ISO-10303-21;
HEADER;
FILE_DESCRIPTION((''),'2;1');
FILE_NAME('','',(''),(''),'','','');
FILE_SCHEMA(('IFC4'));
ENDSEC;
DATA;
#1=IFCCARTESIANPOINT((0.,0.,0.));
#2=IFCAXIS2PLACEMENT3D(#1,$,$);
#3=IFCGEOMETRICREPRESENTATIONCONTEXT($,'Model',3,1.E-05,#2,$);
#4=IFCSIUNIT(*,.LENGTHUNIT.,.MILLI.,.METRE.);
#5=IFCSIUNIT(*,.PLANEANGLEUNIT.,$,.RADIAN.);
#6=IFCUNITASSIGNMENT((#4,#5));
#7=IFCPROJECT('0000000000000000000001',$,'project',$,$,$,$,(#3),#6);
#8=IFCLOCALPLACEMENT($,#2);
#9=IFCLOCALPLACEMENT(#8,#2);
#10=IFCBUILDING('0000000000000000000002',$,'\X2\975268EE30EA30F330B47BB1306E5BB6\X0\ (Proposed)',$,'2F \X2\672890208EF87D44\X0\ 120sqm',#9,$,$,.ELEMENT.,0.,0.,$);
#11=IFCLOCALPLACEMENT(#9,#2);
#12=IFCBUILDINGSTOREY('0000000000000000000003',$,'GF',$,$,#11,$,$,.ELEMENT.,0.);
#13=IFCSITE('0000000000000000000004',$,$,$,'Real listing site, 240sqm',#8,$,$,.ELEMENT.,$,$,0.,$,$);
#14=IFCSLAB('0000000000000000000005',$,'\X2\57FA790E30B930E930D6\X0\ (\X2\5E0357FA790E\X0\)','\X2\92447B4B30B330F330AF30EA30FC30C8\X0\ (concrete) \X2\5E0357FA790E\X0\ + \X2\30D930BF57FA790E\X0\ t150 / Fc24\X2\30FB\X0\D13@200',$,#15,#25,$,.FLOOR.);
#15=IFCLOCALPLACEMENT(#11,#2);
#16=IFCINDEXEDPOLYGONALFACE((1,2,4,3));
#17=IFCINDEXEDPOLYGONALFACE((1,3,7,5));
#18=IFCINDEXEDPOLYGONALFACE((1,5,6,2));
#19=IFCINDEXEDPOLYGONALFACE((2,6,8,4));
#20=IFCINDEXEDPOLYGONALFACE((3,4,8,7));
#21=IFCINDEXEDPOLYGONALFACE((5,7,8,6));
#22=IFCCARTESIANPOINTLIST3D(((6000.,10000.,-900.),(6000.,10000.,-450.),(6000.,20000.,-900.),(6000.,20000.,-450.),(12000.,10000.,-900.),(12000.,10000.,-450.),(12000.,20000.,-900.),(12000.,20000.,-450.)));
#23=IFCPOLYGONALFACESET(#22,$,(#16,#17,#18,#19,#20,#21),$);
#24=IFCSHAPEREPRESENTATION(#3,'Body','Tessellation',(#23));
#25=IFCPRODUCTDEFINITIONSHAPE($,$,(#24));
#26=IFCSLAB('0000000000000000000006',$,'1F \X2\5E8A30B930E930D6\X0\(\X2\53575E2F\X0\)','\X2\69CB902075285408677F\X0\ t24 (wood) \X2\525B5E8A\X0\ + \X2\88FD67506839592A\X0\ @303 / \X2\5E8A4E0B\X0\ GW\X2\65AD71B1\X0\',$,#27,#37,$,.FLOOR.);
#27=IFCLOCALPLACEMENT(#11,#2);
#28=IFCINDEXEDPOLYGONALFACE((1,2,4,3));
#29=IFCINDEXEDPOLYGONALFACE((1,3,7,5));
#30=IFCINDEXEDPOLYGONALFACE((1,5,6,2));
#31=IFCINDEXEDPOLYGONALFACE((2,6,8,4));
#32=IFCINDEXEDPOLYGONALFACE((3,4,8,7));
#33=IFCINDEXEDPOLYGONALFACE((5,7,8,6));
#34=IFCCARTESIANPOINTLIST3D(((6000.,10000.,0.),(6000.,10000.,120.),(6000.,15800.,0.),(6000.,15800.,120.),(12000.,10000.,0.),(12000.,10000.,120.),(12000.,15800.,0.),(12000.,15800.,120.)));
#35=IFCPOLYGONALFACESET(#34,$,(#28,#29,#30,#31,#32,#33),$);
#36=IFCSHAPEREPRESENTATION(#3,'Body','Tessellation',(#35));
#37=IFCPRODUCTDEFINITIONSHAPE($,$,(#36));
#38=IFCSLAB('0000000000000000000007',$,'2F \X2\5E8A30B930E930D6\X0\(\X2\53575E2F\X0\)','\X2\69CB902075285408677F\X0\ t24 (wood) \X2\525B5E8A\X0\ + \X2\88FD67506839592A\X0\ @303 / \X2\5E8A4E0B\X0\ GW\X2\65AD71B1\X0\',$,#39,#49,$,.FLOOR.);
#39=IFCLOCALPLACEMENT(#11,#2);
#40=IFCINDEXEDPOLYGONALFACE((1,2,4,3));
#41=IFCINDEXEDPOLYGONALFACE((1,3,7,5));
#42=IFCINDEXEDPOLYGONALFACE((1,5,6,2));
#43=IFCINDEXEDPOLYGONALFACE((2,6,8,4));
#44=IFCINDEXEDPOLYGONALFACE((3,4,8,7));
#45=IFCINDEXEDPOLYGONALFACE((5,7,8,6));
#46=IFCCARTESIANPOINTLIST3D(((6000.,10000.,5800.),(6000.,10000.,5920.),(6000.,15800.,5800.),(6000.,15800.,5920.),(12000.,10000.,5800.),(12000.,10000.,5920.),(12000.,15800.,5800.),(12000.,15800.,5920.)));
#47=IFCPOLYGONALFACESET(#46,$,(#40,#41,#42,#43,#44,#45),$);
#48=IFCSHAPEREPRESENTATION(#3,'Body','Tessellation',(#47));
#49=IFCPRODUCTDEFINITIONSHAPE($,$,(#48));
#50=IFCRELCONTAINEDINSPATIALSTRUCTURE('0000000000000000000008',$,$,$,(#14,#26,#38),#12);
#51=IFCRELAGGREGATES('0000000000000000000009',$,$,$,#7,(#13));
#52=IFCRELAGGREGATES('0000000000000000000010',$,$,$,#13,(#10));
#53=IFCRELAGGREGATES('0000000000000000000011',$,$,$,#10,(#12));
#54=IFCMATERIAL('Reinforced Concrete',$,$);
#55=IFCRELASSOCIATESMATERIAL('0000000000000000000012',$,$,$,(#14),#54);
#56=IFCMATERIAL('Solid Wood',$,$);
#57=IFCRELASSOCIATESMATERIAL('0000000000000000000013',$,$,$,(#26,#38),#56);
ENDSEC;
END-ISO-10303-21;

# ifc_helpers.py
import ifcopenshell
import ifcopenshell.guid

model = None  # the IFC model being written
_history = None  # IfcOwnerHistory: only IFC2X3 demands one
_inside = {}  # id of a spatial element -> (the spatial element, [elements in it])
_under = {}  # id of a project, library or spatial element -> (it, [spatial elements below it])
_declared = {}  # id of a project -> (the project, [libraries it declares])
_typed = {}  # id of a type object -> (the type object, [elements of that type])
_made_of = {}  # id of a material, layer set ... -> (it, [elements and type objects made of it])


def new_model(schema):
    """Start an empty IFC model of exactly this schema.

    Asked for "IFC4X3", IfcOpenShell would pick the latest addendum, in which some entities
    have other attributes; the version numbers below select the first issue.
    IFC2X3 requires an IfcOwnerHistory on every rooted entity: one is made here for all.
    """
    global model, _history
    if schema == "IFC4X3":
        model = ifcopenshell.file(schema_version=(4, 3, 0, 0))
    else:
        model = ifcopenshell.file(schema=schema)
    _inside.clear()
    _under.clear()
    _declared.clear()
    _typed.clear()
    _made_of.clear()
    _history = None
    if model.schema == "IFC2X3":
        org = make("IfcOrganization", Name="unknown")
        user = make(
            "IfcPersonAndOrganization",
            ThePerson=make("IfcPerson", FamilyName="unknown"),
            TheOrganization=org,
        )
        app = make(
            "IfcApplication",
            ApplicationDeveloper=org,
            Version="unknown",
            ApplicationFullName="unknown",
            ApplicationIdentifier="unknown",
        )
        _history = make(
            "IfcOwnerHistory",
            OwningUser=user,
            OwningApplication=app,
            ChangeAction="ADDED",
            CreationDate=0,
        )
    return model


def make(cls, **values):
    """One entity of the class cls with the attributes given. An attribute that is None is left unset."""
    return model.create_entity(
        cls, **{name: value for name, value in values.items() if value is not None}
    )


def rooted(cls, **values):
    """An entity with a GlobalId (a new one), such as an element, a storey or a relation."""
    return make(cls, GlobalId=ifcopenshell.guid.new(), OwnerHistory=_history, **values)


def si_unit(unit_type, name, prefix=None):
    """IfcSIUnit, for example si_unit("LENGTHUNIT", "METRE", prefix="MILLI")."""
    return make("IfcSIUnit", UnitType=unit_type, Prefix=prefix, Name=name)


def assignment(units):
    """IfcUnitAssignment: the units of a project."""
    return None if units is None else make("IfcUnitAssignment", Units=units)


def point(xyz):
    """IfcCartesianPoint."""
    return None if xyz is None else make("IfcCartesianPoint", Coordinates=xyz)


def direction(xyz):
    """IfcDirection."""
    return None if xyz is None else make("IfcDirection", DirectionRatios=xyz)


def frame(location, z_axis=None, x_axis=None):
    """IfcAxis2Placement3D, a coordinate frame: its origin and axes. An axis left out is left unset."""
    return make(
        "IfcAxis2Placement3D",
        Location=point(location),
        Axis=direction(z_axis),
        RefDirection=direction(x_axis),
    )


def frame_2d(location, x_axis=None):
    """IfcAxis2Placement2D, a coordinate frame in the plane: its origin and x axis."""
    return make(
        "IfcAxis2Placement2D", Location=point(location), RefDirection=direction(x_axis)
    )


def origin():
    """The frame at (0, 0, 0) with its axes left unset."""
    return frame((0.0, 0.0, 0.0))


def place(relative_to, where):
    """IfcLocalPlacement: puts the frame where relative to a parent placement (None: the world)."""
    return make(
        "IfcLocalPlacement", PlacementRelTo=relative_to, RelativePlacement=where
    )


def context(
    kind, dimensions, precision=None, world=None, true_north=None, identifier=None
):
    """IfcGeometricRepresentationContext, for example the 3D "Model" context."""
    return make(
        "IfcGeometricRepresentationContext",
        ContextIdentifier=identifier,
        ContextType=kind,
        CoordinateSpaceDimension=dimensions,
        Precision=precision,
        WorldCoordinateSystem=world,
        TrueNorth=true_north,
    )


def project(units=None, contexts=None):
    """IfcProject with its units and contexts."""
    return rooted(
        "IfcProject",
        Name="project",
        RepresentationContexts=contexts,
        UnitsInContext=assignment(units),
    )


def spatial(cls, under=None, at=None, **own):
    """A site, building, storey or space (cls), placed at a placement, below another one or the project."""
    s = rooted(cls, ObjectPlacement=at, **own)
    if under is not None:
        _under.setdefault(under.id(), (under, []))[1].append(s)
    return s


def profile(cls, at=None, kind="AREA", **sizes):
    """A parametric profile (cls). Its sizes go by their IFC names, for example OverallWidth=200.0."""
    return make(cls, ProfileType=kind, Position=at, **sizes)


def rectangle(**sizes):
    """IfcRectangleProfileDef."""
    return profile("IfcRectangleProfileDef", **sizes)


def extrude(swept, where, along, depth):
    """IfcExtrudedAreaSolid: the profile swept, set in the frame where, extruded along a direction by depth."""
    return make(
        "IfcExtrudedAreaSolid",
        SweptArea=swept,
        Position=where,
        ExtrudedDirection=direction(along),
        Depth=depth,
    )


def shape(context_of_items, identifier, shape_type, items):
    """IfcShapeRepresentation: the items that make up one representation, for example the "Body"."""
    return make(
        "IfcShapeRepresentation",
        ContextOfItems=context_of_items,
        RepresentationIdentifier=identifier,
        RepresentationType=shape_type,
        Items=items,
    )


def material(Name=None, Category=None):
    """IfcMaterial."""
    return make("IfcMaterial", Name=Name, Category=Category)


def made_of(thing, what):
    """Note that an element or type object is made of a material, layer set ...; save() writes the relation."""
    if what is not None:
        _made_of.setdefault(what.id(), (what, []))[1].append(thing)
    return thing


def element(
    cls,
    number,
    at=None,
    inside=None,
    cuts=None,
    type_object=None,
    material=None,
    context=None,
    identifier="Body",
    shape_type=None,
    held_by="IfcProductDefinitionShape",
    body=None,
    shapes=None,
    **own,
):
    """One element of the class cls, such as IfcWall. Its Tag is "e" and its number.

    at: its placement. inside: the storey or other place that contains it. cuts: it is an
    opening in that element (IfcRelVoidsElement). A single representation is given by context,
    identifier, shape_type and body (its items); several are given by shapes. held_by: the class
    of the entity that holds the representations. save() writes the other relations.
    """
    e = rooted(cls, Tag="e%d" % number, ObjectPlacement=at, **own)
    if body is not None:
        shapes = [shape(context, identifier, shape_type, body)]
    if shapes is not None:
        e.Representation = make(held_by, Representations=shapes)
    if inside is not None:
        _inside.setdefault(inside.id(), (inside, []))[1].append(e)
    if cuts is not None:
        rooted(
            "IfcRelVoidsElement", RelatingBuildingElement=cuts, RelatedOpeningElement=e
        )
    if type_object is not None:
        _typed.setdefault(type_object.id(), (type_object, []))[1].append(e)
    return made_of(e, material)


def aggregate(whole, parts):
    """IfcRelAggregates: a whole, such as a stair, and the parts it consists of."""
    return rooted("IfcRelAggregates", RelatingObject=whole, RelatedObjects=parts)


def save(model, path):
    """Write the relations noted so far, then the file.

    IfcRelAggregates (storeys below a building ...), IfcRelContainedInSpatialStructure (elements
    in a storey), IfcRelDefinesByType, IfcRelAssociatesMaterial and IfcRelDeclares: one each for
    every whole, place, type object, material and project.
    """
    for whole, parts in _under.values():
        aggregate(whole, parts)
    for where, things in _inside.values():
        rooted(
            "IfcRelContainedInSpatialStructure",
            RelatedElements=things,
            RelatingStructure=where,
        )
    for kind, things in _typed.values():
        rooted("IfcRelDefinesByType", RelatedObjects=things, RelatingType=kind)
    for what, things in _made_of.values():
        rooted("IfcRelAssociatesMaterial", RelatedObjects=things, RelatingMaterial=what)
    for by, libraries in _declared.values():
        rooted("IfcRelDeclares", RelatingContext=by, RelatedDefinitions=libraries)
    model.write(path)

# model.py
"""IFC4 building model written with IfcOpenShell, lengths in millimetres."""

from ifc_helpers import new_model, si_unit, frame, frame_2d, origin, place, context, project, spatial, rectangle, extrude, material, element, save


model = new_model("IFC4")

# Units and contexts
model_context = context("Model", 3, precision=1e-05, world=origin())
ifc_project = project(units=[si_unit("LENGTHUNIT", "METRE", prefix="MILLI"), si_unit("PLANEANGLEUNIT", "RADIAN")], contexts=[model_context])

# Site, building, storey
site_placement = place(None, origin())
site = spatial("IfcSite", under=ifc_project, at=site_placement, ObjectType="Real listing site, 240sqm", CompositionType="ELEMENT", RefElevation=0.0)
building_placement = place(site_placement, origin())
building = spatial("IfcBuilding", under=site, at=building_placement, Name="青森リンゴ箱の家 (Proposed)", ObjectType="2F 木造軸組 120sqm", CompositionType="ELEMENT", ElevationOfRefHeight=0.0, ElevationOfTerrain=0.0)
storey_placement = place(building_placement, origin())
storey = spatial("IfcBuildingStorey", under=building, at=storey_placement, Name="GF", CompositionType="ELEMENT", Elevation=0.0)

# Slabs
ifc_material_1 = material(Name="Reinforced Concrete")
slab_1_placement = place(storey_placement, frame((3000.0, 5000.0, -450.0)))
element("IfcSlab", 1, at=slab_1_placement, inside=storey, material=ifc_material_1, Name="基礎スラブ (布基礎)", Description="鉄筋コンクリート (concrete) 布基礎 + ベタ基礎 t150 / Fc24・D13@200", PredefinedType="FLOOR", context=model_context, shape_type="SweptSolid", body=[
    extrude(rectangle(XDim=6000.0, YDim=10000.0, at=frame_2d((3000.0, 5000.0))), frame((3000.0, 5000.0, -450.0)), (0.0, 0.0, 1.0), 450.0),
])
ifc_material_2 = material(Name="Solid Wood")
slab_2_placement = place(storey_placement, frame((3000.0, 5000.0, 0.0)))
element("IfcSlab", 2, at=slab_2_placement, inside=storey, material=ifc_material_2, Name="1F 床スラブ(南帯)", Description="構造用合板 t24 (wood) 剛床 + 製材根太 @303 / 床下 GW断熱", PredefinedType="FLOOR", context=model_context, shape_type="SweptSolid", body=[
    extrude(rectangle(XDim=6000.0, YDim=5800.0, at=frame_2d((3000.0, 2900.0))), frame((3000.0, 5000.0, 0.0)), (0.0, 0.0, 1.0), 120.0),
])
slab_3_placement = place(storey_placement, frame((3000.0, 5000.0, 2900.0)))
element("IfcSlab", 3, at=slab_3_placement, inside=storey, material=ifc_material_2, Name="2F 床スラブ(南帯)", Description="構造用合板 t24 (wood) 剛床 + 製材根太 @303 / 床下 GW断熱", PredefinedType="FLOOR", context=model_context, shape_type="SweptSolid", body=[
    extrude(rectangle(XDim=6000.0, YDim=5800.0, at=frame_2d((3000.0, 2900.0))), frame((3000.0, 5000.0, 2900.0)), (0.0, 0.0, 1.0), 120.0),
])

save(model, "model.ifc")
